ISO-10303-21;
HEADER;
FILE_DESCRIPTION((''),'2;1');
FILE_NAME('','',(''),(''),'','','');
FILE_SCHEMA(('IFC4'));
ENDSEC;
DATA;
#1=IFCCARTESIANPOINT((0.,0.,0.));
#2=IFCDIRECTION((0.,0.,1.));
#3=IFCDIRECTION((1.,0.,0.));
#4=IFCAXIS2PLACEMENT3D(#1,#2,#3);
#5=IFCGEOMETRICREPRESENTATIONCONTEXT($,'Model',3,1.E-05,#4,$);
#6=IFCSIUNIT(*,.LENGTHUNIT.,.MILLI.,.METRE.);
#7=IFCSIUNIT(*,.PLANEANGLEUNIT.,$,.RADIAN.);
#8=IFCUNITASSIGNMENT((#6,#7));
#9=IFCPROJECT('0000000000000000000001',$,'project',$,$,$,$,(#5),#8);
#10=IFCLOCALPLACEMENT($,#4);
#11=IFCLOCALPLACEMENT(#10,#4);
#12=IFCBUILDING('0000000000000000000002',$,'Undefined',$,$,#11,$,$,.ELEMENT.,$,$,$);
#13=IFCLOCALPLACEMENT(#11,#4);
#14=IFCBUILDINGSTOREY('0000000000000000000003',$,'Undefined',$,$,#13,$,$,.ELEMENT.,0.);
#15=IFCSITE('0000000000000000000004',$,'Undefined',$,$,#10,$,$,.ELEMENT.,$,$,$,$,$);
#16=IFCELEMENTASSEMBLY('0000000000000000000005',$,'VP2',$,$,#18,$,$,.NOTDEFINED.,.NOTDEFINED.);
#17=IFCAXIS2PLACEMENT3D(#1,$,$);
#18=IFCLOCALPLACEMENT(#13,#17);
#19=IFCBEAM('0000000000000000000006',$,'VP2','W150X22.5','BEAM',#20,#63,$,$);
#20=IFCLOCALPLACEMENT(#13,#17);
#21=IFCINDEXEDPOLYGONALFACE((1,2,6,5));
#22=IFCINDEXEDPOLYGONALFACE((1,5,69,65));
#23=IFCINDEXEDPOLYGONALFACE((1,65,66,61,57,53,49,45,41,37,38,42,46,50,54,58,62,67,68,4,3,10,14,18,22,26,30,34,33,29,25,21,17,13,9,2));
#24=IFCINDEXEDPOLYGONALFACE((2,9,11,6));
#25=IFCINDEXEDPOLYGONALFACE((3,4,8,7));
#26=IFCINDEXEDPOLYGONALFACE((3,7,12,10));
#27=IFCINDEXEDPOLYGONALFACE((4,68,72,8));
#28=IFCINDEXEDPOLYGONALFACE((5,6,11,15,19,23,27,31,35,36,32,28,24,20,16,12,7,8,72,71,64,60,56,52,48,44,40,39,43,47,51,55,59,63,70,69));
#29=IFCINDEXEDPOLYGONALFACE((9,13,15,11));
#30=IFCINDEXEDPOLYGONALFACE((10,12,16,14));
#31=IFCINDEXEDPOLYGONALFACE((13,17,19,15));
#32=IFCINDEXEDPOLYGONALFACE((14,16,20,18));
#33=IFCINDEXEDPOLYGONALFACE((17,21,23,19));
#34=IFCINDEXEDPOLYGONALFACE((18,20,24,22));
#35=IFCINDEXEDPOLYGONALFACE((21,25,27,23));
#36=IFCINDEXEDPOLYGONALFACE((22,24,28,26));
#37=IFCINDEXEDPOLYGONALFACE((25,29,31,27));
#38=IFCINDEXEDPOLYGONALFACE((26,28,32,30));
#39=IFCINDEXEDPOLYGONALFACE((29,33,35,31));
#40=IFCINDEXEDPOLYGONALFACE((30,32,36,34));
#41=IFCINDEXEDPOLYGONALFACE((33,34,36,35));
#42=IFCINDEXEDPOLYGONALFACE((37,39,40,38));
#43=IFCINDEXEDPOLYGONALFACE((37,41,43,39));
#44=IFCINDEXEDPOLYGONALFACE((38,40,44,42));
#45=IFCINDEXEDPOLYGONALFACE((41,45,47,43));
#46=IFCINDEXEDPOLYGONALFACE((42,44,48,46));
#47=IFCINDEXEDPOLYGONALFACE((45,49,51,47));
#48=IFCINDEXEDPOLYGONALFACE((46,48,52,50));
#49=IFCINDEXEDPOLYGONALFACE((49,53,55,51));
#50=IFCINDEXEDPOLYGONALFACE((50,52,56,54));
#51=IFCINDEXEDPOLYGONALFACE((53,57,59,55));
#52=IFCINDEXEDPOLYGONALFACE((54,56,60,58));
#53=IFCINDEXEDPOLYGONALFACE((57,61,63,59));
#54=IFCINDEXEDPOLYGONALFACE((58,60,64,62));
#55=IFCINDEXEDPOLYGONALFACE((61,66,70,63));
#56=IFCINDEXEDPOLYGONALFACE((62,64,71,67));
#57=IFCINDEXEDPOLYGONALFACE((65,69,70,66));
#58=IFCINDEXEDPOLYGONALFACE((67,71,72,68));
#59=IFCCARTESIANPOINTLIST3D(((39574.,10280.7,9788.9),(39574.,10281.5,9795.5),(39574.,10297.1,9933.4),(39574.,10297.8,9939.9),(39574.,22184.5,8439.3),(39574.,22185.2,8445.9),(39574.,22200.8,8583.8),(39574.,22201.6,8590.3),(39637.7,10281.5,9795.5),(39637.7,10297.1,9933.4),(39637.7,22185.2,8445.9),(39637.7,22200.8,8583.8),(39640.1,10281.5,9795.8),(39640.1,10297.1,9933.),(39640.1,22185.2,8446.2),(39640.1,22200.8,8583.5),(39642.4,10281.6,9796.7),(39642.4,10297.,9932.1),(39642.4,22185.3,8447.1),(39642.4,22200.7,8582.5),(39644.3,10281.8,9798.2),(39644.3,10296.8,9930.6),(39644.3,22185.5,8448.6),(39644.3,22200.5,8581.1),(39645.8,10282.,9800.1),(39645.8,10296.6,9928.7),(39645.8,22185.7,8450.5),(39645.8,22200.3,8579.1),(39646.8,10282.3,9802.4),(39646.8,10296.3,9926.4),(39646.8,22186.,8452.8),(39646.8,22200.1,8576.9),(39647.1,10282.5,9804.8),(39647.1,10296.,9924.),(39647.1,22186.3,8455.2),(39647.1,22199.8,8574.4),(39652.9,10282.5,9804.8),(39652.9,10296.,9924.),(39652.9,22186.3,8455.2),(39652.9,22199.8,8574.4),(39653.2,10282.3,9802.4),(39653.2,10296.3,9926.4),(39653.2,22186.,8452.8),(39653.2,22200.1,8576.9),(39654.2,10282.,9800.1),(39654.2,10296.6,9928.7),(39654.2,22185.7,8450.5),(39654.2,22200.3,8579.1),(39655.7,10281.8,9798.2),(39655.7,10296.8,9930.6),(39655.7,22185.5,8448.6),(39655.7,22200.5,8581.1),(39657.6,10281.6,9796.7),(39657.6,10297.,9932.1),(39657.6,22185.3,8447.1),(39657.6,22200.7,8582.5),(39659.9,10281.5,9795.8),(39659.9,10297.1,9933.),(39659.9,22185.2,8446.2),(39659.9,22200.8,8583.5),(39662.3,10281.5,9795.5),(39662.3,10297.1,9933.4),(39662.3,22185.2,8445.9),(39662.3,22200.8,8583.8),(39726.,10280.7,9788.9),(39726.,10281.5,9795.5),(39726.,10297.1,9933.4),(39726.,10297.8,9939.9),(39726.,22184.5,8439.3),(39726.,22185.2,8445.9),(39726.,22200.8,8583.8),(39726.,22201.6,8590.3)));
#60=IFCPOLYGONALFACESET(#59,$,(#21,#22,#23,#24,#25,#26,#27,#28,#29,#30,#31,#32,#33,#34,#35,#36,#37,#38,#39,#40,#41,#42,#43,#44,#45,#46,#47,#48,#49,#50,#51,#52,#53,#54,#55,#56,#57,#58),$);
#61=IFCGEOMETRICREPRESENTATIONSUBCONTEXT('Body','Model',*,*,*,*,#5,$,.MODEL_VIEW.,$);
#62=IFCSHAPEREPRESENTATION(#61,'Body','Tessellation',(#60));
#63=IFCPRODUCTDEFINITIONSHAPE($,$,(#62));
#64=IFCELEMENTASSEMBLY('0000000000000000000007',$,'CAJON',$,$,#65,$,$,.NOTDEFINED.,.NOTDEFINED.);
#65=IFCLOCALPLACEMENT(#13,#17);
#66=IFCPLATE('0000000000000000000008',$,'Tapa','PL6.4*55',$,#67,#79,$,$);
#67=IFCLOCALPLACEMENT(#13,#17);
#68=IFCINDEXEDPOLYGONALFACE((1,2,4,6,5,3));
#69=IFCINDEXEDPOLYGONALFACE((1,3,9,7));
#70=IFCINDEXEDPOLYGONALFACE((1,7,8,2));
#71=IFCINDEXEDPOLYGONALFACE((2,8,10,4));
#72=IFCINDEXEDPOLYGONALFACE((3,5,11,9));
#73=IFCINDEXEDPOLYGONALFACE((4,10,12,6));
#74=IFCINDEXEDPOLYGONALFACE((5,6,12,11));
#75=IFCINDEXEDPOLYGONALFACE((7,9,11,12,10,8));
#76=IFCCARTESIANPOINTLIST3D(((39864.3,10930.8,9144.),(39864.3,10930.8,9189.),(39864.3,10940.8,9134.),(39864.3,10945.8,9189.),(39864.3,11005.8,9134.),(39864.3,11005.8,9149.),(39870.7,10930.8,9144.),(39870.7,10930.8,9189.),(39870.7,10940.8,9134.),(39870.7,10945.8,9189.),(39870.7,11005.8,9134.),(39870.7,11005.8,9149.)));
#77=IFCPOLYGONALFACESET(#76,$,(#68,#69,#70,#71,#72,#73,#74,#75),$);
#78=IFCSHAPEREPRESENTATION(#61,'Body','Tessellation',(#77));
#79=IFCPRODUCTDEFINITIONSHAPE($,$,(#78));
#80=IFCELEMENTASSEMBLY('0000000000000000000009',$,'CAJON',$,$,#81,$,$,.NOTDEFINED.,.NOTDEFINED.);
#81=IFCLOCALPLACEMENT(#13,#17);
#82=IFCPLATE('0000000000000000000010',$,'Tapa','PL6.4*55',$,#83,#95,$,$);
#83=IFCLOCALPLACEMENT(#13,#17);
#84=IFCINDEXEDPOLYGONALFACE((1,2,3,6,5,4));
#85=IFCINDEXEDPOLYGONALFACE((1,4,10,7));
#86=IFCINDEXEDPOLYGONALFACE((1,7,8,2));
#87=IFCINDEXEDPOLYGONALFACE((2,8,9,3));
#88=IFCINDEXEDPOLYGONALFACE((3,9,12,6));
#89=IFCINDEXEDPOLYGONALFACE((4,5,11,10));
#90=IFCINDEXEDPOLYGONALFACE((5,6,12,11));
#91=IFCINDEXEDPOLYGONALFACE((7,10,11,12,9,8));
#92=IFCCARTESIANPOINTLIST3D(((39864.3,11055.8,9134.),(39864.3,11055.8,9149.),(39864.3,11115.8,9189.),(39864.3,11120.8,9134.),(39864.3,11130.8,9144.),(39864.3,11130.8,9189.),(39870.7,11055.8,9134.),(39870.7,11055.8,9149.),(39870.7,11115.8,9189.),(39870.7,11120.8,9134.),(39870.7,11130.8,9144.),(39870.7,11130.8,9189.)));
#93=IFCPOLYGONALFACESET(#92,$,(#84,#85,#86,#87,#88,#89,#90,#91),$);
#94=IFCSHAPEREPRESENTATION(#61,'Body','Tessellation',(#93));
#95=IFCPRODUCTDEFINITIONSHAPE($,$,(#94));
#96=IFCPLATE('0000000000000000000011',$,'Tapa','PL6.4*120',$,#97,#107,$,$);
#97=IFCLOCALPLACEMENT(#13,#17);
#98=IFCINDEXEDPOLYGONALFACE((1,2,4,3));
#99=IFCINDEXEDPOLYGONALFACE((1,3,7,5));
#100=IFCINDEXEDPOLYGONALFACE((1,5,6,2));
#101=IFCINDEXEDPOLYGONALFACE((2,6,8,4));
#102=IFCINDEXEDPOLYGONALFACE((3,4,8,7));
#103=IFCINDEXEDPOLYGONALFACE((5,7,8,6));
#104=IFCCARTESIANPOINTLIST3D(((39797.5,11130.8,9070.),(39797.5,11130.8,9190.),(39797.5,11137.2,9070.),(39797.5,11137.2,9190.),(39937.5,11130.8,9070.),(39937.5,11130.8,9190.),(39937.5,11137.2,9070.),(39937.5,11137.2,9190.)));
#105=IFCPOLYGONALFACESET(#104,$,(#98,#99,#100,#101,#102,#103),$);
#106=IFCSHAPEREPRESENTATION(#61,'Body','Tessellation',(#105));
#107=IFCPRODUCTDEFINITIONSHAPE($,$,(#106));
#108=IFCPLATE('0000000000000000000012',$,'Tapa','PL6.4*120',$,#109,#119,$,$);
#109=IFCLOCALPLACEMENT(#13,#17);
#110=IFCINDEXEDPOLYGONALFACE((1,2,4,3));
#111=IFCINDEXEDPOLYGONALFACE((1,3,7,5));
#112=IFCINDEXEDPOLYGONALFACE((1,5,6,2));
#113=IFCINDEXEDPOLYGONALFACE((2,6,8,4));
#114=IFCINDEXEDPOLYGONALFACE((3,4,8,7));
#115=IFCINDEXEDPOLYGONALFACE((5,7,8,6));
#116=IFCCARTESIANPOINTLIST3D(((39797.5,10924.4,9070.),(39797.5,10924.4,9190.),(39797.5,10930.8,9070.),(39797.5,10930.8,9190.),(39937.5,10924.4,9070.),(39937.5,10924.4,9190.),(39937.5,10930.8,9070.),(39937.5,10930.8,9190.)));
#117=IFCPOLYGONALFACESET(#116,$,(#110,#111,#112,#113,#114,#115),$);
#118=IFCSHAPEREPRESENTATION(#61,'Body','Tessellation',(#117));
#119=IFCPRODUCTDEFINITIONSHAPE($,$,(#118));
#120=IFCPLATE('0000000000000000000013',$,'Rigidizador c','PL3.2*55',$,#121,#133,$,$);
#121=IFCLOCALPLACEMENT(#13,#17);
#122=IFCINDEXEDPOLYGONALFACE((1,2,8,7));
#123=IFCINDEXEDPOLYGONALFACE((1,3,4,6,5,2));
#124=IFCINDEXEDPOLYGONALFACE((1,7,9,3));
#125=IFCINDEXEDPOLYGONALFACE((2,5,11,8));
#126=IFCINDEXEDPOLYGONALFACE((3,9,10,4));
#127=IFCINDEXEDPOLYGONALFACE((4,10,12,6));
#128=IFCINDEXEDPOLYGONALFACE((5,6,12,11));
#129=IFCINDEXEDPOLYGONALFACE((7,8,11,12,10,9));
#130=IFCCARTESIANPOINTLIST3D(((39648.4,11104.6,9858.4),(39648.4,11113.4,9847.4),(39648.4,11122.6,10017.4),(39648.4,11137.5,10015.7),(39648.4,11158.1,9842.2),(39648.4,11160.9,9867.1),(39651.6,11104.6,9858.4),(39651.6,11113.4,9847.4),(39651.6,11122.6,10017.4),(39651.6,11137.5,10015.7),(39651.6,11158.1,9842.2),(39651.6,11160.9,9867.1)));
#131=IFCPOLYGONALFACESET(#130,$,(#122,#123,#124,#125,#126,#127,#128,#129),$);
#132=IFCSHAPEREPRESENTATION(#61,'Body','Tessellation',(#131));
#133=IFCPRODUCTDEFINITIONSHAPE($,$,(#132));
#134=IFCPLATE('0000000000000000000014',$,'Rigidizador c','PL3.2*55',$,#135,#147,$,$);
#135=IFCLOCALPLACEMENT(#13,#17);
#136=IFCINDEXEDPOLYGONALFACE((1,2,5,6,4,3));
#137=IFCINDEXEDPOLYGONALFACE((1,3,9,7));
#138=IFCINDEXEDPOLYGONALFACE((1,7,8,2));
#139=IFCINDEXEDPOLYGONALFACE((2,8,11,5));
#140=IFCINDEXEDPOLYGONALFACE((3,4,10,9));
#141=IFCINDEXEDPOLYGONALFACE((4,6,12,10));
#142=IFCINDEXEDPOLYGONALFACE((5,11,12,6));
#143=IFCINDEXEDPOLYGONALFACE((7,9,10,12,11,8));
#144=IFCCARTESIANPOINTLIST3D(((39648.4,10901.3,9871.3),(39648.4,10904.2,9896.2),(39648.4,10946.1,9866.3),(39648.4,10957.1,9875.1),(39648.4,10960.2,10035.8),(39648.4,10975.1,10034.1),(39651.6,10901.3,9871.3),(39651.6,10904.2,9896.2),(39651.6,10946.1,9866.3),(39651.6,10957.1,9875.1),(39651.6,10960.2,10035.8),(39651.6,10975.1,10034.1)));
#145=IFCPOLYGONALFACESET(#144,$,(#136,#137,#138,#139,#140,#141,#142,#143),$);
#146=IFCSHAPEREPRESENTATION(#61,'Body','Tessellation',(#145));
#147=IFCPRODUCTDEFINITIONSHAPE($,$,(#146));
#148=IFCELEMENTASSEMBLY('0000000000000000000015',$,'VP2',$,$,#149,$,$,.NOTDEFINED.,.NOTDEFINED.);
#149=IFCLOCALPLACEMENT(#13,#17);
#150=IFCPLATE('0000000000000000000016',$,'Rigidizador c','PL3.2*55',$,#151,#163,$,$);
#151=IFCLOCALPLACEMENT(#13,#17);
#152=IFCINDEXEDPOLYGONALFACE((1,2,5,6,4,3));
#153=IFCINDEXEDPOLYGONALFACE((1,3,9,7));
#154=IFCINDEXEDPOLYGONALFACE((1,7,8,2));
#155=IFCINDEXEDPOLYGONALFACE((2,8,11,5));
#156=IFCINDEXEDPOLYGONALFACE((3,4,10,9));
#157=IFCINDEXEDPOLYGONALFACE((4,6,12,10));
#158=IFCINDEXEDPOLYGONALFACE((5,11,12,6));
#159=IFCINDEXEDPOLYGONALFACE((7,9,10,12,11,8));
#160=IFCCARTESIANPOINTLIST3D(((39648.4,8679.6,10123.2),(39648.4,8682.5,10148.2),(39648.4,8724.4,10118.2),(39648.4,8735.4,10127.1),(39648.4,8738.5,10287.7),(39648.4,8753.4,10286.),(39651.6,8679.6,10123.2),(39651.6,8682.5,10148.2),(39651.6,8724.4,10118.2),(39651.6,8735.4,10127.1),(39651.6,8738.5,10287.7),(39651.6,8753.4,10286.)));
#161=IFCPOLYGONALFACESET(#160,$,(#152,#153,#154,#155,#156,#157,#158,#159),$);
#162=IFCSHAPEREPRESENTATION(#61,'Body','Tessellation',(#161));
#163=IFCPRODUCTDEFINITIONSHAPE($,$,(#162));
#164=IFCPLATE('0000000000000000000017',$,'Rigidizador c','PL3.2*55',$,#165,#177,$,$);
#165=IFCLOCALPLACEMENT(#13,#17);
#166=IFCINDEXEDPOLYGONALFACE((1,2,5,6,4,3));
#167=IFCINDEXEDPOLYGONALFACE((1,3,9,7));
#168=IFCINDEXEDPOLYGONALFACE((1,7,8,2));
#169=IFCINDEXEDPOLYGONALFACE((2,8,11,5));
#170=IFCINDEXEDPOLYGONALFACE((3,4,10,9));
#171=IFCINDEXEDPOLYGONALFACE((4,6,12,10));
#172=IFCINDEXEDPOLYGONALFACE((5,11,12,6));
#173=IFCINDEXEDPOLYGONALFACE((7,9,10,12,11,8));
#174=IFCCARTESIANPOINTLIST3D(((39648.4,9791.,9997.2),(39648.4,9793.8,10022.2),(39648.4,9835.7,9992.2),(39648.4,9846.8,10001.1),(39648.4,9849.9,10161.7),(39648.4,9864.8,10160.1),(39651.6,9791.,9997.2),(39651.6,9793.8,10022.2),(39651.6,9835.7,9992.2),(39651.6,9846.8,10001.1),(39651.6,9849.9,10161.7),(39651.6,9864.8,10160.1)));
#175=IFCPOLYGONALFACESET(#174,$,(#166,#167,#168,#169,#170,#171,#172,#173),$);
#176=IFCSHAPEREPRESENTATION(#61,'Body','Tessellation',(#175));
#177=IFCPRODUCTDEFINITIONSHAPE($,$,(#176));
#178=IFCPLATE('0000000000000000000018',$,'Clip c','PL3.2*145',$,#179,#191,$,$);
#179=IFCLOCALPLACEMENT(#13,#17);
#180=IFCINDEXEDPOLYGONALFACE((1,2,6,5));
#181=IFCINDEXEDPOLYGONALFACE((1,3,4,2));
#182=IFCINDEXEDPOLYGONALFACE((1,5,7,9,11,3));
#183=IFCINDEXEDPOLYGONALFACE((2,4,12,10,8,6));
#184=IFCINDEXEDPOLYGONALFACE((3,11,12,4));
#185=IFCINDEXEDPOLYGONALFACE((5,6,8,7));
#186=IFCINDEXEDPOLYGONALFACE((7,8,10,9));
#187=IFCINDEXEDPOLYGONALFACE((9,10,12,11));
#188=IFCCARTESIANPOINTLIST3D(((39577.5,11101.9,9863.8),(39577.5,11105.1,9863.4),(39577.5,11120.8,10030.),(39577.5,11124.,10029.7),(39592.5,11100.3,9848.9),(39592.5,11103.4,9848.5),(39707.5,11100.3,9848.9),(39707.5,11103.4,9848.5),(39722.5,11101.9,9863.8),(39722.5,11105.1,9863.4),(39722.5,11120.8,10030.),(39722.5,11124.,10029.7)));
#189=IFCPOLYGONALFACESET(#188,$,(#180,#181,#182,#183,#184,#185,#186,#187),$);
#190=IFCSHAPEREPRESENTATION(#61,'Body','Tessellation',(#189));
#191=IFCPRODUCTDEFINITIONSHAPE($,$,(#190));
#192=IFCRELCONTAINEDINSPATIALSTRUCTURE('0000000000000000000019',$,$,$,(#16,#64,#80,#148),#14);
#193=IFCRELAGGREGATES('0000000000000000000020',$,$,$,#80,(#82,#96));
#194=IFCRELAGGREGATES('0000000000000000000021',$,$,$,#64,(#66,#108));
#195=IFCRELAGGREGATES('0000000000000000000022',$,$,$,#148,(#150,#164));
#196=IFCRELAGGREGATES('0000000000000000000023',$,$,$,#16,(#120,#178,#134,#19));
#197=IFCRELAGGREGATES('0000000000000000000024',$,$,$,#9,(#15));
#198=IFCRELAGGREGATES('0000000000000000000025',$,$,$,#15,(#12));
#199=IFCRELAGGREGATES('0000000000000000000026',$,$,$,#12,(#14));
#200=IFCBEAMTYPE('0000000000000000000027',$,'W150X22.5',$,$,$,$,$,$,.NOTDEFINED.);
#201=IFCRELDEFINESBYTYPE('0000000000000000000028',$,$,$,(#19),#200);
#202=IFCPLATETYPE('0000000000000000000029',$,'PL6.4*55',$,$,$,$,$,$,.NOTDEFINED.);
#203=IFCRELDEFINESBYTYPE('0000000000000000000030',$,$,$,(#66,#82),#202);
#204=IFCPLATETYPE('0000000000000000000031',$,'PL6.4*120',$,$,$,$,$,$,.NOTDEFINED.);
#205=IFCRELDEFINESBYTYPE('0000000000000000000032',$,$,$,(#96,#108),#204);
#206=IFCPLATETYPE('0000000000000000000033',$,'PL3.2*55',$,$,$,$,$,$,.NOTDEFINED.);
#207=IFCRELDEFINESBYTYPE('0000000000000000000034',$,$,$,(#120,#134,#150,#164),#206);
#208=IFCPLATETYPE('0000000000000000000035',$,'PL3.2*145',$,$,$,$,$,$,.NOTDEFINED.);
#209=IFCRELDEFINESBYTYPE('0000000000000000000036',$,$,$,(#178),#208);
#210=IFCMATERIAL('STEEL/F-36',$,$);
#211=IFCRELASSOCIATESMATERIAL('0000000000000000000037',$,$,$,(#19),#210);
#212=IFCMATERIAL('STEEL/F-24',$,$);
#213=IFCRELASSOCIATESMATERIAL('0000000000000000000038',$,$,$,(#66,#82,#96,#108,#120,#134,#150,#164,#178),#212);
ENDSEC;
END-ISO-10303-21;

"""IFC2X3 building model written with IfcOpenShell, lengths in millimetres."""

from ifc_helpers import new_model, si_unit, frame, origin_with_axes, origin_2d_with_axis, place, context, subcontext, project, spatial, polyline, i_section, outline, extrude, material, type_object, element, aggregate, save


model = new_model("IFC2X3")

# Units and contexts
model_context = context("Model", 3, precision=1e-05, world=origin_with_axes())
body_context = subcontext(model_context, "Body", "Model", "MODEL_VIEW")
ifc_project = project(units=[si_unit("LENGTHUNIT", "METRE", prefix="MILLI"), si_unit("PLANEANGLEUNIT", "RADIAN")], contexts=[model_context])

# Site, building, storey
site_placement = place(None, origin_with_axes())
site = spatial("IfcSite", under=ifc_project, at=site_placement, Name="Undefined", CompositionType="ELEMENT")
building_placement = place(site_placement, origin_with_axes())
building = spatial("IfcBuilding", under=site, at=building_placement, Name="Undefined", CompositionType="ELEMENT")
storey_placement = place(building_placement, origin_with_axes())
storey = spatial("IfcBuildingStorey", under=building, at=storey_placement, Name="Undefined", CompositionType="ELEMENT", Elevation=0.0)

# Element assembly, beam
assembly_1_placement = place(storey_placement, origin_with_axes())
assembly_1 = element("IfcElementAssembly", 1, at=assembly_1_placement, inside=storey, Name="VP2", AssemblyPlace="NOTDEFINED", PredefinedType="NOTDEFINED")
ifc_material_1 = material(Name="STEEL/F-36")
beam_type = type_object("IfcBeamType", Name="W150X22.5", PredefinedType="NOTDEFINED")
beam_placement = place(assembly_1_placement, frame((39650.0, 10289.3, 9864.4), z_axis=(0.000001, 0.112653, 0.993634), x_axis=(0.0, 0.993634, -0.112653)))
beam = element("IfcBeam", 2, at=beam_placement, type_object=beam_type, material=ifc_material_1, Name="VP2", Description="W150X22.5", ObjectType="BEAM", context=body_context, shape_type="SweptSolid", body=[
    extrude(i_section(OverallWidth=152.0, OverallDepth=152.0, WebThickness=5.8, FlangeThickness=6.6, FilletRadius=9.4, at=origin_2d_with_axis()), frame((11980.0, 0.0, 0.0), z_axis=(-1.0, 0.0, 0.0), x_axis=(0.0, -1.0, 0.0)), (0.0, 0.0, 1.0), 11980.0),
])

# Element assembly, plate
assembly_2_placement = place(storey_placement, origin_with_axes())
assembly_2 = element("IfcElementAssembly", 3, at=assembly_2_placement, inside=storey, Name="CAJON", AssemblyPlace="NOTDEFINED", PredefinedType="NOTDEFINED")
ifc_material_2 = material(Name="STEEL/F-24")
plate_type_1 = type_object("IfcPlateType", Name="PL6.4*55", PredefinedType="NOTDEFINED")
plate_1_placement = place(assembly_2_placement, frame((39867.5, 11005.8, 9134.0), z_axis=(-1.0, 0.0, 0.0), x_axis=(0.0, -1.0, 0.0)))
plate_1 = element("IfcPlate", 4, at=plate_1_placement, type_object=plate_type_1, material=ifc_material_2, Name="Tapa", Description="PL6.4*55", context=body_context, shape_type="SweptSolid", body=[
    extrude(outline(polyline([(0.0, 0.0), (65.0, 0.0), (75.0, 10.0), (75.0, 55.0), (60.0, 55.0), (0.0, 15.0), (0.0, 0.0)])), frame((0.0, 0.0, -3.2), z_axis=(0.0, 0.0, 1.0), x_axis=(1.0, 0.0, 0.0)), (0.0, 0.0, 1.0), 6.4),
])

# Element assembly, plates
assembly_3_placement = place(storey_placement, origin_with_axes())
assembly_3 = element("IfcElementAssembly", 5, at=assembly_3_placement, inside=storey, Name="CAJON", AssemblyPlace="NOTDEFINED", PredefinedType="NOTDEFINED")
plate_2_placement = place(assembly_3_placement, frame((39867.5, 11055.8, 9134.0), z_axis=(1.0, 0.0, 0.0), x_axis=(0.0, 1.0, 0.0)))
plate_2 = element("IfcPlate", 6, at=plate_2_placement, type_object=plate_type_1, material=ifc_material_2, Name="Tapa", Description="PL6.4*55", context=body_context, shape_type="SweptSolid", body=[
    extrude(outline(polyline([(0.0, 0.0), (65.0, 0.0), (75.0, 10.0), (75.0, 55.0), (60.0, 55.0), (0.0, 15.0), (0.0, 0.0)])), frame((0.0, 0.0, -3.2), z_axis=(0.0, 0.0, 1.0), x_axis=(1.0, 0.0, 0.0)), (0.0, 0.0, 1.0), 6.4),
])
plate_type_2 = type_object("IfcPlateType", Name="PL6.4*120", PredefinedType="NOTDEFINED")
plate_3_placement = place(assembly_3_placement, frame((39937.5, 11134.0, 9190.0), z_axis=(0.0, 1.0, 0.0), x_axis=(0.0, 0.0, -1.0)))
plate_3 = element("IfcPlate", 7, at=plate_3_placement, type_object=plate_type_2, material=ifc_material_2, Name="Tapa", Description="PL6.4*120", context=body_context, shape_type="SweptSolid", body=[
    extrude(outline(polyline([(0.0, 0.0), (120.0, 0.0), (120.0, 140.0), (0.0, 140.0), (0.0, 0.0)])), frame((0.0, 0.0, -3.2), z_axis=(0.0, 0.0, 1.0), x_axis=(1.0, 0.0, 0.0)), (0.0, 0.0, 1.0), 6.4),
])
aggregate(assembly_3, [plate_2, plate_3])

# Plates
plate_4_placement = place(assembly_2_placement, frame((39937.5, 10927.6, 9190.0), z_axis=(0.0, 1.0, 0.0), x_axis=(0.0, 0.0, -1.0)))
plate_4 = element("IfcPlate", 8, at=plate_4_placement, type_object=plate_type_2, material=ifc_material_2, Name="Tapa", Description="PL6.4*120", context=body_context, shape_type="SweptSolid", body=[
    extrude(outline(polyline([(0.0, 0.0), (120.0, 0.0), (120.0, 140.0), (0.0, 140.0), (0.0, 0.0)])), frame((0.0, 0.0, -3.2), z_axis=(0.0, 0.0, 1.0), x_axis=(1.0, 0.0, 0.0)), (0.0, 0.0, 1.0), 6.4),
])
aggregate(assembly_2, [plate_1, plate_4])
plate_type_3 = type_object("IfcPlateType", Name="PL3.2*55", PredefinedType="NOTDEFINED")
plate_5_placement = place(assembly_1_placement, frame((39650.0, 11122.6, 10017.4), z_axis=(-1.0, 0.0, 0.0), x_axis=(0.0, 0.993635, -0.112644)))
plate_5 = element("IfcPlate", 9, at=plate_5_placement, type_object=plate_type_3, material=ifc_material_2, Name="Rigidizador c", Description="PL3.2*55", context=body_context, shape_type="SweptSolid", body=[
    extrude(outline(polyline([(0.0, 0.0), (15.0, 0.0), (55.0, 145.0), (55.0, 170.1), (10.0, 170.0), (0.0, 160.0), (0.0, 0.0)])), frame((0.0, 0.0, -1.6), z_axis=(0.0, 0.0, 1.0), x_axis=(1.0, 0.0, 0.0)), (0.0, 0.0, 1.0), 3.2),
])
plate_6_placement = place(assembly_1_placement, frame((39650.0, 10975.1, 10034.1), z_axis=(1.0, 0.0, 0.0), x_axis=(0.0, -0.993635, 0.112644)))
plate_6 = element("IfcPlate", 10, at=plate_6_placement, type_object=plate_type_3, material=ifc_material_2, Name="Rigidizador c", Description="PL3.2*55", context=body_context, shape_type="SweptSolid", body=[
    extrude(outline(polyline([(0.0, 0.0), (15.0, 0.0), (55.0, 145.0), (55.0, 170.1), (10.0, 170.0), (0.0, 160.0), (0.0, 0.0)])), frame((0.0, 0.0, -1.6), z_axis=(0.0, 0.0, 1.0), x_axis=(1.0, 0.0, 0.0)), (0.0, 0.0, 1.0), 3.2),
])

# Element assembly, plates
assembly_4_placement = place(storey_placement, origin_with_axes())
assembly_4 = element("IfcElementAssembly", 11, at=assembly_4_placement, inside=storey, Name="VP2", AssemblyPlace="NOTDEFINED", PredefinedType="NOTDEFINED")
plate_7_placement = place(assembly_4_placement, frame((39650.0, 8753.4, 10286.0), z_axis=(1.0, 0.0, 0.0), x_axis=(0.0, -0.993635, 0.112644)))
plate_7 = element("IfcPlate", 12, at=plate_7_placement, type_object=plate_type_3, material=ifc_material_2, Name="Rigidizador c", Description="PL3.2*55", context=body_context, shape_type="SweptSolid", body=[
    extrude(outline(polyline([(0.0, 0.0), (15.0, 0.0), (55.0, 145.0), (55.0, 170.1), (10.0, 170.0), (0.0, 160.0), (0.0, 0.0)])), frame((0.0, 0.0, -1.6), z_axis=(0.0, 0.0, 1.0), x_axis=(1.0, 0.0, 0.0)), (0.0, 0.0, 1.0), 3.2),
])
plate_8_placement = place(assembly_4_placement, frame((39650.0, 9864.8, 10160.1), z_axis=(1.0, 0.0, 0.0), x_axis=(0.0, -0.993635, 0.112644)))
plate_8 = element("IfcPlate", 13, at=plate_8_placement, type_object=plate_type_3, material=ifc_material_2, Name="Rigidizador c", Description="PL3.2*55", context=body_context, shape_type="SweptSolid", body=[
    extrude(outline(polyline([(0.0, 0.0), (15.0, 0.0), (55.0, 145.0), (55.0, 170.1), (10.0, 170.0), (0.0, 160.0), (0.0, 0.0)])), frame((0.0, 0.0, -1.6), z_axis=(0.0, 0.0, 1.0), x_axis=(1.0, 0.0, 0.0)), (0.0, 0.0, 1.0), 3.2),
])

# Plate
plate_type_4 = type_object("IfcPlateType", Name="PL3.2*145", PredefinedType="NOTDEFINED")
plate_9_placement = place(assembly_1_placement, frame((39722.5, 11101.8, 9848.7), z_axis=(0.0, -0.993626, 0.112729), x_axis=(0.0, 0.112729, 0.993626)))
plate_9 = element("IfcPlate", 14, at=plate_9_placement, type_object=plate_type_4, material=ifc_material_2, Name="Clip c", Description="PL3.2*145", context=body_context, shape_type="SweptSolid", body=[
    extrude(outline(polyline([(0.0, 15.0), (15.0, 0.0), (182.3, 0.0), (182.3, 145.0), (15.0, 145.0), (0.0, 130.0), (0.0, 15.0)])), frame((0.0, 0.0, -1.6), z_axis=(0.0, 0.0, 1.0), x_axis=(1.0, 0.0, 0.0)), (0.0, 0.0, 1.0), 3.2),
])

aggregate(assembly_4, [plate_7, plate_8])
aggregate(assembly_1, [plate_5, plate_9, plate_6, beam])

save(model, "model.ifc")
